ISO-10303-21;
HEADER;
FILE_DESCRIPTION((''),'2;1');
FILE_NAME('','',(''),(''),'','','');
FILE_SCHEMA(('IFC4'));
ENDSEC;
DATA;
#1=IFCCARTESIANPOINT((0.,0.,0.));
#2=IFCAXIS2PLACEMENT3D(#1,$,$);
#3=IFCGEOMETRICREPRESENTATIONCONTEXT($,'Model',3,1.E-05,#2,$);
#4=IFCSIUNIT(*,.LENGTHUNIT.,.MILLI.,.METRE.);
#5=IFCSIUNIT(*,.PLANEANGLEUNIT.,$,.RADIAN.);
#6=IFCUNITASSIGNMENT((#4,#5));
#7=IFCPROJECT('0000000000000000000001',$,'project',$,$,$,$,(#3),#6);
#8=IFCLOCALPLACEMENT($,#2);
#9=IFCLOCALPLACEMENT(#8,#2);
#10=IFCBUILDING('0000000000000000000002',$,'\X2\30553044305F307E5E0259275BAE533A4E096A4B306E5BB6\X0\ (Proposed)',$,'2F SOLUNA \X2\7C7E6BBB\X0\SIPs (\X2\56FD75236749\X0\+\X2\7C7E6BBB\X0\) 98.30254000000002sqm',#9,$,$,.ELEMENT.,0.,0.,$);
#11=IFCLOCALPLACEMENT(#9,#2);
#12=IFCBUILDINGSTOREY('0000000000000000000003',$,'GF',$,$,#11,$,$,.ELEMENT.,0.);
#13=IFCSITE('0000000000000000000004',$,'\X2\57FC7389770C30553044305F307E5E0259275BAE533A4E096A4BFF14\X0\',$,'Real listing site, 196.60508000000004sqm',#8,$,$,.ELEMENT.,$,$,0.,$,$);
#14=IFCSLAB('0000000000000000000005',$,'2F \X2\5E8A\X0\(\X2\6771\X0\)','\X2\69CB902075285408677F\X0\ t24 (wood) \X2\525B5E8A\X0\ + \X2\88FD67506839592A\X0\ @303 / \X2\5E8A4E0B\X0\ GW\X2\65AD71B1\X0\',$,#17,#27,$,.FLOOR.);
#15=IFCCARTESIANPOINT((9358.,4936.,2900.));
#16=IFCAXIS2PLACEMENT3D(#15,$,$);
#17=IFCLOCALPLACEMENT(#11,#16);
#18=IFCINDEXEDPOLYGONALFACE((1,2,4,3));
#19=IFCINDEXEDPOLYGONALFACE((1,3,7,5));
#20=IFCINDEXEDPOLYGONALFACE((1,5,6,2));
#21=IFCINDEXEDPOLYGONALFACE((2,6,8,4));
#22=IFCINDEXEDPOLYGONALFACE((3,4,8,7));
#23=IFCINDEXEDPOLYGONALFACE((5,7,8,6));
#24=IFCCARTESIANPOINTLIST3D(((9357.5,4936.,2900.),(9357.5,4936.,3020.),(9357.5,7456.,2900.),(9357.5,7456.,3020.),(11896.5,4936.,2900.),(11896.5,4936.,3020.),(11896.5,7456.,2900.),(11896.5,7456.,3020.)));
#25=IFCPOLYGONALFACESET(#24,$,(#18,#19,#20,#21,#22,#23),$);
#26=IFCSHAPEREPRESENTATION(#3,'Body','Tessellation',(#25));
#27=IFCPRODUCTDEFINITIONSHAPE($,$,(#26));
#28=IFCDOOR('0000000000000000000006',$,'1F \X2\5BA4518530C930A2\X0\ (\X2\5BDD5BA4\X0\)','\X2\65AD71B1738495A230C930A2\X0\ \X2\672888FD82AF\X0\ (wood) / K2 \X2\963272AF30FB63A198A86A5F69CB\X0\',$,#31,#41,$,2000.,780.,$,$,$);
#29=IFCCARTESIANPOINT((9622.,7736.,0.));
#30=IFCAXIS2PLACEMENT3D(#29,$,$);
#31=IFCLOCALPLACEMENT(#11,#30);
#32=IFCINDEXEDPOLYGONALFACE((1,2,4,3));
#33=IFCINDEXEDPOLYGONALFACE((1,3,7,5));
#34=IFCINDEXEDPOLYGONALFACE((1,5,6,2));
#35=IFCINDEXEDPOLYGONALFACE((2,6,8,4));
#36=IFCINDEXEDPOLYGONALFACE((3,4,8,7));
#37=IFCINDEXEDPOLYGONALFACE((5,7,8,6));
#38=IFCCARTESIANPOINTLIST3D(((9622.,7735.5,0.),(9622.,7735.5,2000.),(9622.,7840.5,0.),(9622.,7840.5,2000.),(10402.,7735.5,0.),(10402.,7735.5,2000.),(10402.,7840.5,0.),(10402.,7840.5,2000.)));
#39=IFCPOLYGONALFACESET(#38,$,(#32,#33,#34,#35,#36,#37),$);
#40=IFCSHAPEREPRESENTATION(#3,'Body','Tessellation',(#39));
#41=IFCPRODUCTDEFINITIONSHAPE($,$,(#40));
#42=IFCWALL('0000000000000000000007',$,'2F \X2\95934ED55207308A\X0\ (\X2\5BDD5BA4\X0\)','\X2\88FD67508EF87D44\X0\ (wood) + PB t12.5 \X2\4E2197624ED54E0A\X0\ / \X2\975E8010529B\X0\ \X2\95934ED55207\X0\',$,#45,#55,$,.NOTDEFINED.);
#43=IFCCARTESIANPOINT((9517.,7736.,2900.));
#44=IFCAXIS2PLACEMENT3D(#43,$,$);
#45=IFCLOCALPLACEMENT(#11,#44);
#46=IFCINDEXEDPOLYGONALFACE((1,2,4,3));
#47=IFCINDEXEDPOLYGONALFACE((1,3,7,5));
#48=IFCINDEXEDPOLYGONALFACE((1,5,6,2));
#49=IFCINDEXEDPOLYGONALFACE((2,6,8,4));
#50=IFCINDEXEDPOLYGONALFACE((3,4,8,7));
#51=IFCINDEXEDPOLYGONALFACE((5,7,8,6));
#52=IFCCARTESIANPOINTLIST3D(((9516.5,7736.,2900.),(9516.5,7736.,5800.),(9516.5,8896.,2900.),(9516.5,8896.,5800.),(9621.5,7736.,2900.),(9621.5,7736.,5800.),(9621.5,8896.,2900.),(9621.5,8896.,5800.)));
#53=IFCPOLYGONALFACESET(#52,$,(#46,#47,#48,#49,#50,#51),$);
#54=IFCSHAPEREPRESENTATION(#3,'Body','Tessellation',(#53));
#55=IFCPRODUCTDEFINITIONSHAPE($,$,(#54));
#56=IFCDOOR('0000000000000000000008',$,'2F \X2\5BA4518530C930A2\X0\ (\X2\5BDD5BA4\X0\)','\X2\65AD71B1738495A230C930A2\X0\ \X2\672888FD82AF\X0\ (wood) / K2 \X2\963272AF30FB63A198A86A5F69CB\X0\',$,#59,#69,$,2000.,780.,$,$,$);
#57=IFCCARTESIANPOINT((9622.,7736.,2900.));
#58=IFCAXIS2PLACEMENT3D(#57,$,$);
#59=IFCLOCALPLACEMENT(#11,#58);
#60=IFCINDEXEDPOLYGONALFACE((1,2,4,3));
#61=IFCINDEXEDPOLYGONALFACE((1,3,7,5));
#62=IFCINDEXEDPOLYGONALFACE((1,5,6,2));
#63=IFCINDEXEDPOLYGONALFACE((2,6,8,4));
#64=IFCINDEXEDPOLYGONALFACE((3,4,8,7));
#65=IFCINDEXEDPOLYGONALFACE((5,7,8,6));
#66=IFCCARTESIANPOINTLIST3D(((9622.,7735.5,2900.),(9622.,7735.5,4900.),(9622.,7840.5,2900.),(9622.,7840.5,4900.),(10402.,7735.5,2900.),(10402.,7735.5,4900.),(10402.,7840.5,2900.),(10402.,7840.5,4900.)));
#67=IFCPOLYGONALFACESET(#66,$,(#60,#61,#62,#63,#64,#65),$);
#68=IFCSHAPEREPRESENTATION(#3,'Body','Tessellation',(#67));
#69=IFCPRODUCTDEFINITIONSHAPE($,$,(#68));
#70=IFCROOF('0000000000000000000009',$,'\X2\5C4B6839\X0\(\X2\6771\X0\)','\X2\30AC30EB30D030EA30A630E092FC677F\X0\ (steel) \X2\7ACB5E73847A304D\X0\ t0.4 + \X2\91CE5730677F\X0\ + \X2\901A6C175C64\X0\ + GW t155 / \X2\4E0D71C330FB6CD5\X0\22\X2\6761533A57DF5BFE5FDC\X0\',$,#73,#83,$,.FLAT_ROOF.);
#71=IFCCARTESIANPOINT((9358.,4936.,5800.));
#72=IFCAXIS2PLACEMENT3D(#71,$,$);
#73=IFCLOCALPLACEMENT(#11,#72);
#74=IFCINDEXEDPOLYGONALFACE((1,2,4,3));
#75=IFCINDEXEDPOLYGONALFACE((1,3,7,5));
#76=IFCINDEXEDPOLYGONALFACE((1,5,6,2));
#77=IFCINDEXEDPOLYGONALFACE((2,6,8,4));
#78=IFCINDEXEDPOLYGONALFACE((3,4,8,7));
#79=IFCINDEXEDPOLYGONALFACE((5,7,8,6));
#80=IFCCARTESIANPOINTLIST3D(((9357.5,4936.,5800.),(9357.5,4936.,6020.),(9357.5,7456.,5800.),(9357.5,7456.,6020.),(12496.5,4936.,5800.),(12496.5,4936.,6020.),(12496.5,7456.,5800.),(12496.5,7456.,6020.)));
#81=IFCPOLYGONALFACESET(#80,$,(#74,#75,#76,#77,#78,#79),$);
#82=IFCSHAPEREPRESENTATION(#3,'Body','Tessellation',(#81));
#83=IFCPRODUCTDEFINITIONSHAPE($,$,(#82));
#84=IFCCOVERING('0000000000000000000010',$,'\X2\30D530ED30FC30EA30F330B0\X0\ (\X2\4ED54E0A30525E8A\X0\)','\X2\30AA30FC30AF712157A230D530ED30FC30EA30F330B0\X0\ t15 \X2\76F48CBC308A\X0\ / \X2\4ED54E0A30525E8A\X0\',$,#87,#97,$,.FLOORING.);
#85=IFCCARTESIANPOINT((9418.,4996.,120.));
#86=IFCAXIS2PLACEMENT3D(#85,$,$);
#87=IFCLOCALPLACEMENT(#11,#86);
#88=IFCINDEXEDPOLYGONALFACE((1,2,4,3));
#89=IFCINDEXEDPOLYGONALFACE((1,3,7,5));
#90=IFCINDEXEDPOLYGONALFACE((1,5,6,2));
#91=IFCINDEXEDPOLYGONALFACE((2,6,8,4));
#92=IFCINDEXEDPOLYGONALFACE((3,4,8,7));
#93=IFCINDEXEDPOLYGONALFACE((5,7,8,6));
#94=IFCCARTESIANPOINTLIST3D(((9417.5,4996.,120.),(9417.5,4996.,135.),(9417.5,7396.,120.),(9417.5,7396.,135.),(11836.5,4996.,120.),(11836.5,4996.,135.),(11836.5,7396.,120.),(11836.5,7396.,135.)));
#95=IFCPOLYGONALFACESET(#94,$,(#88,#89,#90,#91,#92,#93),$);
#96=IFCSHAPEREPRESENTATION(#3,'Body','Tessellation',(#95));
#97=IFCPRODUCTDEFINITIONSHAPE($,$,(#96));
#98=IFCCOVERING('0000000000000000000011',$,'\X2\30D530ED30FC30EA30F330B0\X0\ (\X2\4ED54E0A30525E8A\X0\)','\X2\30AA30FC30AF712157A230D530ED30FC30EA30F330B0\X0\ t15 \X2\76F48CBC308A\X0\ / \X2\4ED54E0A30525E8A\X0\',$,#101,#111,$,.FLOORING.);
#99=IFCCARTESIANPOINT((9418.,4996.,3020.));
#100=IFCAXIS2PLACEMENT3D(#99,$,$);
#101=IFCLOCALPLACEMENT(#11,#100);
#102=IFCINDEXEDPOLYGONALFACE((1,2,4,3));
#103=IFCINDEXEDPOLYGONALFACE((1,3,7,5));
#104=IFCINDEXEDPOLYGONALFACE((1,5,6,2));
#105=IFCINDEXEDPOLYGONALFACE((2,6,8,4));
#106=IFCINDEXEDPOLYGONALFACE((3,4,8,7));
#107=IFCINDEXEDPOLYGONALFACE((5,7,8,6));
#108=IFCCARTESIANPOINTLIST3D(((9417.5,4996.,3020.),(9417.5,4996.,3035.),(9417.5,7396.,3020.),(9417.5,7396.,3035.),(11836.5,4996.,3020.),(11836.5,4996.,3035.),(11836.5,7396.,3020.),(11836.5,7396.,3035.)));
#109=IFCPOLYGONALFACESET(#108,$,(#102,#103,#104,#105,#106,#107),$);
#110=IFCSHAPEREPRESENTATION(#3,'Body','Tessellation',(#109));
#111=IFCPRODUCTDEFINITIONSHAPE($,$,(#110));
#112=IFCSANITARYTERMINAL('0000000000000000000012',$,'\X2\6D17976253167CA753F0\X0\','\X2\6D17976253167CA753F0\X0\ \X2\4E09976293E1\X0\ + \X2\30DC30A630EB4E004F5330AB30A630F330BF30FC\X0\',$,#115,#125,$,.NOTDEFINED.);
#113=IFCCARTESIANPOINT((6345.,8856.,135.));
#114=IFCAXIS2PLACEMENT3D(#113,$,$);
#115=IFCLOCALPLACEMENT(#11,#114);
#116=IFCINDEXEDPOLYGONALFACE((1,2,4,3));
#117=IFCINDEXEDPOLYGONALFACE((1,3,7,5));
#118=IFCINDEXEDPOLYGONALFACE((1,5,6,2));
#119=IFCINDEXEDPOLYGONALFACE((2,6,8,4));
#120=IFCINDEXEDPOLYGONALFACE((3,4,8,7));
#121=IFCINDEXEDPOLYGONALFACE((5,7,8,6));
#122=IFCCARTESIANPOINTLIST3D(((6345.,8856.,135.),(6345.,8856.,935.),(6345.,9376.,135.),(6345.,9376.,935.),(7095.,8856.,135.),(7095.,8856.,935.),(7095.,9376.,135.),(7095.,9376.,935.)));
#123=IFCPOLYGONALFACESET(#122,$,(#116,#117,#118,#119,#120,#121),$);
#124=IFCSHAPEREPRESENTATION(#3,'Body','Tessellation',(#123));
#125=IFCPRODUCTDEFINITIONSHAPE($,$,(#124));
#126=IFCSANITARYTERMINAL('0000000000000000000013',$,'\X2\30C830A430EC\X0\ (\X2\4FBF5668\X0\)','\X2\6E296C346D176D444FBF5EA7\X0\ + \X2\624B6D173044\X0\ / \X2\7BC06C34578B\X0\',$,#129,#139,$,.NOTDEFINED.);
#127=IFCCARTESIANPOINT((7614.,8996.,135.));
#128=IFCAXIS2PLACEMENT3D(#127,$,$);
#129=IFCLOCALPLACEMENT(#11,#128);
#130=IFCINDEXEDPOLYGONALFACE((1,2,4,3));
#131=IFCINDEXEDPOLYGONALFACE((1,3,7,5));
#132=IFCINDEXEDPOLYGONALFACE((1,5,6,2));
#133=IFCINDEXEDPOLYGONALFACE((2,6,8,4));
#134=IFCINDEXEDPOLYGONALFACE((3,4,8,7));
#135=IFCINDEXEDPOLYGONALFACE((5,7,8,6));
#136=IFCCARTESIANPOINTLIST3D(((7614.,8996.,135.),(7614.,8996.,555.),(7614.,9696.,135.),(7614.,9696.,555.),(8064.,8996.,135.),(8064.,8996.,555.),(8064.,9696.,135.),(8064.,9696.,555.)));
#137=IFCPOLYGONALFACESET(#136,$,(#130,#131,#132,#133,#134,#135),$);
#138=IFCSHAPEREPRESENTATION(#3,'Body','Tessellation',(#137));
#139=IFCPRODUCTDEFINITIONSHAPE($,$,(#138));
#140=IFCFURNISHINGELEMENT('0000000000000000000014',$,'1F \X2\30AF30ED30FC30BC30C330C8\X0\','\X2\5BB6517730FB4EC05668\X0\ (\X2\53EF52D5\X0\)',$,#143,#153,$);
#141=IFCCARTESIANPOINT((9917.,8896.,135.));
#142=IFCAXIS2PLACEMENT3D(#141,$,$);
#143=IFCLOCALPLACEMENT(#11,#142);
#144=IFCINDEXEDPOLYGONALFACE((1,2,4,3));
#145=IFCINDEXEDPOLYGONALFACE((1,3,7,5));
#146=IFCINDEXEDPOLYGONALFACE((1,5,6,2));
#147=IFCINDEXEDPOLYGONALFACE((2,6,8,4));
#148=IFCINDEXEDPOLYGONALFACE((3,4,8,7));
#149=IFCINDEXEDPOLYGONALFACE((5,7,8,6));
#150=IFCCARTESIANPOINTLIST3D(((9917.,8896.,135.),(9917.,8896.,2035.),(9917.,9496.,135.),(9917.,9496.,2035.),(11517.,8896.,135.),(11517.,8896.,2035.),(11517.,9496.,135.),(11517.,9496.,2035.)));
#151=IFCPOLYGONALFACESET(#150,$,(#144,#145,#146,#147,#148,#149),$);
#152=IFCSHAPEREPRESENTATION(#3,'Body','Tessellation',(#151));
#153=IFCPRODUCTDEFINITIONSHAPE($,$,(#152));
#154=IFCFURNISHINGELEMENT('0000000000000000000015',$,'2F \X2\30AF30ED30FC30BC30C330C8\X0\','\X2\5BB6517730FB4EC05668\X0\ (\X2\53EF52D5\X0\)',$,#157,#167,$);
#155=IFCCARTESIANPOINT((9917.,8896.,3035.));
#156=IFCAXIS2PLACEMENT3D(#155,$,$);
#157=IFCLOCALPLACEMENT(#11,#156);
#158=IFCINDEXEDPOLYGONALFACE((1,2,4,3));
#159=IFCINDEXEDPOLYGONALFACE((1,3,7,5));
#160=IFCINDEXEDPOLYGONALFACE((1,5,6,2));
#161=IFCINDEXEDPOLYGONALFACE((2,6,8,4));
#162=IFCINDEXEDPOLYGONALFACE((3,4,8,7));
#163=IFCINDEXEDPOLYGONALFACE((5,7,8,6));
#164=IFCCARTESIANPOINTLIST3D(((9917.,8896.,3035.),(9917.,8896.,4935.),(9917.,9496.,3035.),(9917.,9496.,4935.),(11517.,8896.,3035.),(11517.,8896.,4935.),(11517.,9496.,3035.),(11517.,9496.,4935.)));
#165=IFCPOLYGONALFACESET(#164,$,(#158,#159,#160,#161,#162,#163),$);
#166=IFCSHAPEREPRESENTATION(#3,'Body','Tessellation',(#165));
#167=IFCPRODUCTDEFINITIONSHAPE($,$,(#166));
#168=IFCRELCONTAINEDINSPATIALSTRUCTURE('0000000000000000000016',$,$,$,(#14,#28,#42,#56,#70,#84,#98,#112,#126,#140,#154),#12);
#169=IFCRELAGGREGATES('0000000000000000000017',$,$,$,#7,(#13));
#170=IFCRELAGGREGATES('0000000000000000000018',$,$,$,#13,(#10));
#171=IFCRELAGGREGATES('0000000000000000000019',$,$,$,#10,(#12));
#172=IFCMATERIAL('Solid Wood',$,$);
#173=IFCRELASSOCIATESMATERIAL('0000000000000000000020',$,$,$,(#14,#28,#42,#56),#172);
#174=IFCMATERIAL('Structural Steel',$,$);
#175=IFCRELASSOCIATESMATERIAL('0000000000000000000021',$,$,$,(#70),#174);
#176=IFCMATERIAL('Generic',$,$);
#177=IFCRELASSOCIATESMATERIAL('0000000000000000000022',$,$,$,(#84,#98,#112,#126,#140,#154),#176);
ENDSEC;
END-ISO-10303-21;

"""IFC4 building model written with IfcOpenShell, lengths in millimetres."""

from ifc_helpers import new_model, si_unit, frame, frame_2d, origin, place, context, project, spatial, rectangle, extrude, material, element, save


model = new_model("IFC4")

# Units and contexts
model_context = context("Model", 3, precision=1e-05, world=origin())
ifc_project = project(units=[si_unit("LENGTHUNIT", "METRE", prefix="MILLI"), si_unit("PLANEANGLEUNIT", "RADIAN")], contexts=[model_context])

# Site, building, storey
site_placement = place(None, origin())
site = spatial("IfcSite", under=ifc_project, at=site_placement, Name="埼玉県さいたま市大宮区三橋４", ObjectType="Real listing site, 196.60508000000004sqm", CompositionType="ELEMENT", RefElevation=0.0)
building_placement = place(site_placement, origin())
building = spatial("IfcBuilding", under=site, at=building_placement, Name="さいたま市大宮区三橋の家 (Proposed)", ObjectType="2F SOLUNA 籾殻SIPs (国産杉+籾殻) 98.30254000000002sqm", CompositionType="ELEMENT", ElevationOfRefHeight=0.0, ElevationOfTerrain=0.0)
storey_placement = place(building_placement, origin())
storey = spatial("IfcBuildingStorey", under=building, at=storey_placement, Name="GF", CompositionType="ELEMENT", Elevation=0.0)

# Slab
ifc_material_1 = material(Name="Solid Wood")
slab_1_placement = place(storey_placement, frame((9358.0, 4936.0, 2900.0)))
element("IfcSlab", 1, at=slab_1_placement, inside=storey, material=ifc_material_1, Name="2F 床(東)", Description="構造用合板 t24 (wood) 剛床 + 製材根太 @303 / 床下 GW断熱", PredefinedType="FLOOR", context=model_context, shape_type="SweptSolid", body=[
    extrude(rectangle(XDim=2539.0, YDim=2520.0, at=frame_2d((1269.0, 1260.0))), frame((9358.0, 4936.0, 2900.0)), (0.0, 0.0, 1.0), 120.0),
])

# Door
door_1_placement = place(storey_placement, frame((9622.0, 7736.0, 0.0)))
element("IfcDoor", 2, at=door_1_placement, inside=storey, material=ifc_material_1, Name="1F 室内ドア (寝室)", Description="断熱玄関ドア 木製芯 (wood) / K2 防犯・採風機構", OverallHeight=2000.0, OverallWidth=780.0, context=model_context, shape_type="SweptSolid", body=[
    extrude(rectangle(XDim=780.0, YDim=105.0, at=frame_2d((390.0, 52.0))), frame((9622.0, 7736.0, 0.0)), (0.0, 0.0, 1.0), 2000.0),
])

# Wall
wall_1_placement = place(storey_placement, frame((9517.0, 7736.0, 2900.0)))
element("IfcWall", 3, at=wall_1_placement, inside=storey, material=ifc_material_1, Name="2F 間仕切り (寝室)", Description="製材軸組 (wood) + PB t12.5 両面仕上 / 非耐力 間仕切", PredefinedType="NOTDEFINED", context=model_context, shape_type="SweptSolid", body=[
    extrude(rectangle(XDim=105.0, YDim=1160.0, at=frame_2d((52.0, 580.0))), frame((9517.0, 7736.0, 2900.0)), (0.0, 0.0, 1.0), 2900.0),
])

# Door
door_2_placement = place(storey_placement, frame((9622.0, 7736.0, 2900.0)))
element("IfcDoor", 4, at=door_2_placement, inside=storey, material=ifc_material_1, Name="2F 室内ドア (寝室)", Description="断熱玄関ドア 木製芯 (wood) / K2 防犯・採風機構", OverallHeight=2000.0, OverallWidth=780.0, context=model_context, shape_type="SweptSolid", body=[
    extrude(rectangle(XDim=780.0, YDim=105.0, at=frame_2d((390.0, 52.0))), frame((9622.0, 7736.0, 2900.0)), (0.0, 0.0, 1.0), 2000.0),
])

# Roof
ifc_material_2 = material(Name="Structural Steel")
for number, where, name in (
    (5, (9358.0, 4936.0, 5800.0), "屋根(東)"),
):
    element("IfcRoof", number, at=place(storey_placement, frame(where)), inside=storey, material=ifc_material_2, Name=name, Description="ガルバリウム鋼板 (steel) 立平葺き t0.4 + 野地板 + 通気層 + GW t155 / 不燃・法22条区域対応", PredefinedType="FLAT_ROOF", context=model_context, shape_type="SweptSolid", body=[
        extrude(rectangle(XDim=3139.0, YDim=2520.0, at=frame_2d((1569.0, 1260.0))), frame((9358.0, 4936.0, 5800.0)), (0.0, 0.0, 1.0), 220.0),
    ])

# Coverings
ifc_material_3 = material(Name="Generic")
covering_1_placement = place(storey_placement, frame((9418.0, 4996.0, 120.0)))
element("IfcCovering", 6, at=covering_1_placement, inside=storey, material=ifc_material_3, Name="フローリング (仕上げ床)", Description="オーク無垢フローリング t15 直貼り / 仕上げ床", PredefinedType="FLOORING", context=model_context, shape_type="SweptSolid", body=[
    extrude(rectangle(XDim=2419.0, YDim=2400.0, at=frame_2d((1209.0, 1200.0))), frame((9418.0, 4996.0, 120.0)), (0.0, 0.0, 1.0), 15.0),
])
covering_2_placement = place(storey_placement, frame((9418.0, 4996.0, 3020.0)))
element("IfcCovering", 7, at=covering_2_placement, inside=storey, material=ifc_material_3, Name="フローリング (仕上げ床)", Description="オーク無垢フローリング t15 直貼り / 仕上げ床", PredefinedType="FLOORING", context=model_context, shape_type="SweptSolid", body=[
    extrude(rectangle(XDim=2419.0, YDim=2400.0, at=frame_2d((1209.0, 1200.0))), frame((9418.0, 4996.0, 3020.0)), (0.0, 0.0, 1.0), 15.0),
])

# Sanitary terminals
sanitary_terminal_1_placement = place(storey_placement, frame((6345.0, 8856.0, 135.0)))
element("IfcSanitaryTerminal", 8, at=sanitary_terminal_1_placement, inside=storey, material=ifc_material_3, Name="洗面化粧台", Description="洗面化粧台 三面鏡 + ボウル一体カウンター", PredefinedType="NOTDEFINED", context=model_context, shape_type="SweptSolid", body=[
    extrude(rectangle(XDim=750.0, YDim=520.0, at=frame_2d((375.0, 260.0))), frame((6345.0, 8856.0, 135.0)), (0.0, 0.0, 1.0), 800.0),
])
sanitary_terminal_2_placement = place(storey_placement, frame((7614.0, 8996.0, 135.0)))
element("IfcSanitaryTerminal", 9, at=sanitary_terminal_2_placement, inside=storey, material=ifc_material_3, Name="トイレ (便器)", Description="温水洗浄便座 + 手洗い / 節水型", PredefinedType="NOTDEFINED", context=model_context, shape_type="SweptSolid", body=[
    extrude(rectangle(XDim=450.0, YDim=700.0, at=frame_2d((225.0, 350.0))), frame((7614.0, 8996.0, 135.0)), (0.0, 0.0, 1.0), 420.0),
])

# Furnishing elements
furnishing_1_placement = place(storey_placement, frame((9917.0, 8896.0, 135.0)))
element("IfcFurnishingElement", 10, at=furnishing_1_placement, inside=storey, material=ifc_material_3, Name="1F クローゼット", Description="家具・什器 (可動)", context=model_context, shape_type="SweptSolid", body=[
    extrude(rectangle(XDim=1600.0, YDim=600.0, at=frame_2d((800.0, 300.0))), frame((9917.0, 8896.0, 135.0)), (0.0, 0.0, 1.0), 1900.0),
])
furnishing_2_placement = place(storey_placement, frame((9917.0, 8896.0, 3035.0)))
element("IfcFurnishingElement", 11, at=furnishing_2_placement, inside=storey, material=ifc_material_3, Name="2F クローゼット", Description="家具・什器 (可動)", context=model_context, shape_type="SweptSolid", body=[
    extrude(rectangle(XDim=1600.0, YDim=600.0, at=frame_2d((800.0, 300.0))), frame((9917.0, 8896.0, 3035.0)), (0.0, 0.0, 1.0), 1900.0),
])

save(model, "model.ifc")
